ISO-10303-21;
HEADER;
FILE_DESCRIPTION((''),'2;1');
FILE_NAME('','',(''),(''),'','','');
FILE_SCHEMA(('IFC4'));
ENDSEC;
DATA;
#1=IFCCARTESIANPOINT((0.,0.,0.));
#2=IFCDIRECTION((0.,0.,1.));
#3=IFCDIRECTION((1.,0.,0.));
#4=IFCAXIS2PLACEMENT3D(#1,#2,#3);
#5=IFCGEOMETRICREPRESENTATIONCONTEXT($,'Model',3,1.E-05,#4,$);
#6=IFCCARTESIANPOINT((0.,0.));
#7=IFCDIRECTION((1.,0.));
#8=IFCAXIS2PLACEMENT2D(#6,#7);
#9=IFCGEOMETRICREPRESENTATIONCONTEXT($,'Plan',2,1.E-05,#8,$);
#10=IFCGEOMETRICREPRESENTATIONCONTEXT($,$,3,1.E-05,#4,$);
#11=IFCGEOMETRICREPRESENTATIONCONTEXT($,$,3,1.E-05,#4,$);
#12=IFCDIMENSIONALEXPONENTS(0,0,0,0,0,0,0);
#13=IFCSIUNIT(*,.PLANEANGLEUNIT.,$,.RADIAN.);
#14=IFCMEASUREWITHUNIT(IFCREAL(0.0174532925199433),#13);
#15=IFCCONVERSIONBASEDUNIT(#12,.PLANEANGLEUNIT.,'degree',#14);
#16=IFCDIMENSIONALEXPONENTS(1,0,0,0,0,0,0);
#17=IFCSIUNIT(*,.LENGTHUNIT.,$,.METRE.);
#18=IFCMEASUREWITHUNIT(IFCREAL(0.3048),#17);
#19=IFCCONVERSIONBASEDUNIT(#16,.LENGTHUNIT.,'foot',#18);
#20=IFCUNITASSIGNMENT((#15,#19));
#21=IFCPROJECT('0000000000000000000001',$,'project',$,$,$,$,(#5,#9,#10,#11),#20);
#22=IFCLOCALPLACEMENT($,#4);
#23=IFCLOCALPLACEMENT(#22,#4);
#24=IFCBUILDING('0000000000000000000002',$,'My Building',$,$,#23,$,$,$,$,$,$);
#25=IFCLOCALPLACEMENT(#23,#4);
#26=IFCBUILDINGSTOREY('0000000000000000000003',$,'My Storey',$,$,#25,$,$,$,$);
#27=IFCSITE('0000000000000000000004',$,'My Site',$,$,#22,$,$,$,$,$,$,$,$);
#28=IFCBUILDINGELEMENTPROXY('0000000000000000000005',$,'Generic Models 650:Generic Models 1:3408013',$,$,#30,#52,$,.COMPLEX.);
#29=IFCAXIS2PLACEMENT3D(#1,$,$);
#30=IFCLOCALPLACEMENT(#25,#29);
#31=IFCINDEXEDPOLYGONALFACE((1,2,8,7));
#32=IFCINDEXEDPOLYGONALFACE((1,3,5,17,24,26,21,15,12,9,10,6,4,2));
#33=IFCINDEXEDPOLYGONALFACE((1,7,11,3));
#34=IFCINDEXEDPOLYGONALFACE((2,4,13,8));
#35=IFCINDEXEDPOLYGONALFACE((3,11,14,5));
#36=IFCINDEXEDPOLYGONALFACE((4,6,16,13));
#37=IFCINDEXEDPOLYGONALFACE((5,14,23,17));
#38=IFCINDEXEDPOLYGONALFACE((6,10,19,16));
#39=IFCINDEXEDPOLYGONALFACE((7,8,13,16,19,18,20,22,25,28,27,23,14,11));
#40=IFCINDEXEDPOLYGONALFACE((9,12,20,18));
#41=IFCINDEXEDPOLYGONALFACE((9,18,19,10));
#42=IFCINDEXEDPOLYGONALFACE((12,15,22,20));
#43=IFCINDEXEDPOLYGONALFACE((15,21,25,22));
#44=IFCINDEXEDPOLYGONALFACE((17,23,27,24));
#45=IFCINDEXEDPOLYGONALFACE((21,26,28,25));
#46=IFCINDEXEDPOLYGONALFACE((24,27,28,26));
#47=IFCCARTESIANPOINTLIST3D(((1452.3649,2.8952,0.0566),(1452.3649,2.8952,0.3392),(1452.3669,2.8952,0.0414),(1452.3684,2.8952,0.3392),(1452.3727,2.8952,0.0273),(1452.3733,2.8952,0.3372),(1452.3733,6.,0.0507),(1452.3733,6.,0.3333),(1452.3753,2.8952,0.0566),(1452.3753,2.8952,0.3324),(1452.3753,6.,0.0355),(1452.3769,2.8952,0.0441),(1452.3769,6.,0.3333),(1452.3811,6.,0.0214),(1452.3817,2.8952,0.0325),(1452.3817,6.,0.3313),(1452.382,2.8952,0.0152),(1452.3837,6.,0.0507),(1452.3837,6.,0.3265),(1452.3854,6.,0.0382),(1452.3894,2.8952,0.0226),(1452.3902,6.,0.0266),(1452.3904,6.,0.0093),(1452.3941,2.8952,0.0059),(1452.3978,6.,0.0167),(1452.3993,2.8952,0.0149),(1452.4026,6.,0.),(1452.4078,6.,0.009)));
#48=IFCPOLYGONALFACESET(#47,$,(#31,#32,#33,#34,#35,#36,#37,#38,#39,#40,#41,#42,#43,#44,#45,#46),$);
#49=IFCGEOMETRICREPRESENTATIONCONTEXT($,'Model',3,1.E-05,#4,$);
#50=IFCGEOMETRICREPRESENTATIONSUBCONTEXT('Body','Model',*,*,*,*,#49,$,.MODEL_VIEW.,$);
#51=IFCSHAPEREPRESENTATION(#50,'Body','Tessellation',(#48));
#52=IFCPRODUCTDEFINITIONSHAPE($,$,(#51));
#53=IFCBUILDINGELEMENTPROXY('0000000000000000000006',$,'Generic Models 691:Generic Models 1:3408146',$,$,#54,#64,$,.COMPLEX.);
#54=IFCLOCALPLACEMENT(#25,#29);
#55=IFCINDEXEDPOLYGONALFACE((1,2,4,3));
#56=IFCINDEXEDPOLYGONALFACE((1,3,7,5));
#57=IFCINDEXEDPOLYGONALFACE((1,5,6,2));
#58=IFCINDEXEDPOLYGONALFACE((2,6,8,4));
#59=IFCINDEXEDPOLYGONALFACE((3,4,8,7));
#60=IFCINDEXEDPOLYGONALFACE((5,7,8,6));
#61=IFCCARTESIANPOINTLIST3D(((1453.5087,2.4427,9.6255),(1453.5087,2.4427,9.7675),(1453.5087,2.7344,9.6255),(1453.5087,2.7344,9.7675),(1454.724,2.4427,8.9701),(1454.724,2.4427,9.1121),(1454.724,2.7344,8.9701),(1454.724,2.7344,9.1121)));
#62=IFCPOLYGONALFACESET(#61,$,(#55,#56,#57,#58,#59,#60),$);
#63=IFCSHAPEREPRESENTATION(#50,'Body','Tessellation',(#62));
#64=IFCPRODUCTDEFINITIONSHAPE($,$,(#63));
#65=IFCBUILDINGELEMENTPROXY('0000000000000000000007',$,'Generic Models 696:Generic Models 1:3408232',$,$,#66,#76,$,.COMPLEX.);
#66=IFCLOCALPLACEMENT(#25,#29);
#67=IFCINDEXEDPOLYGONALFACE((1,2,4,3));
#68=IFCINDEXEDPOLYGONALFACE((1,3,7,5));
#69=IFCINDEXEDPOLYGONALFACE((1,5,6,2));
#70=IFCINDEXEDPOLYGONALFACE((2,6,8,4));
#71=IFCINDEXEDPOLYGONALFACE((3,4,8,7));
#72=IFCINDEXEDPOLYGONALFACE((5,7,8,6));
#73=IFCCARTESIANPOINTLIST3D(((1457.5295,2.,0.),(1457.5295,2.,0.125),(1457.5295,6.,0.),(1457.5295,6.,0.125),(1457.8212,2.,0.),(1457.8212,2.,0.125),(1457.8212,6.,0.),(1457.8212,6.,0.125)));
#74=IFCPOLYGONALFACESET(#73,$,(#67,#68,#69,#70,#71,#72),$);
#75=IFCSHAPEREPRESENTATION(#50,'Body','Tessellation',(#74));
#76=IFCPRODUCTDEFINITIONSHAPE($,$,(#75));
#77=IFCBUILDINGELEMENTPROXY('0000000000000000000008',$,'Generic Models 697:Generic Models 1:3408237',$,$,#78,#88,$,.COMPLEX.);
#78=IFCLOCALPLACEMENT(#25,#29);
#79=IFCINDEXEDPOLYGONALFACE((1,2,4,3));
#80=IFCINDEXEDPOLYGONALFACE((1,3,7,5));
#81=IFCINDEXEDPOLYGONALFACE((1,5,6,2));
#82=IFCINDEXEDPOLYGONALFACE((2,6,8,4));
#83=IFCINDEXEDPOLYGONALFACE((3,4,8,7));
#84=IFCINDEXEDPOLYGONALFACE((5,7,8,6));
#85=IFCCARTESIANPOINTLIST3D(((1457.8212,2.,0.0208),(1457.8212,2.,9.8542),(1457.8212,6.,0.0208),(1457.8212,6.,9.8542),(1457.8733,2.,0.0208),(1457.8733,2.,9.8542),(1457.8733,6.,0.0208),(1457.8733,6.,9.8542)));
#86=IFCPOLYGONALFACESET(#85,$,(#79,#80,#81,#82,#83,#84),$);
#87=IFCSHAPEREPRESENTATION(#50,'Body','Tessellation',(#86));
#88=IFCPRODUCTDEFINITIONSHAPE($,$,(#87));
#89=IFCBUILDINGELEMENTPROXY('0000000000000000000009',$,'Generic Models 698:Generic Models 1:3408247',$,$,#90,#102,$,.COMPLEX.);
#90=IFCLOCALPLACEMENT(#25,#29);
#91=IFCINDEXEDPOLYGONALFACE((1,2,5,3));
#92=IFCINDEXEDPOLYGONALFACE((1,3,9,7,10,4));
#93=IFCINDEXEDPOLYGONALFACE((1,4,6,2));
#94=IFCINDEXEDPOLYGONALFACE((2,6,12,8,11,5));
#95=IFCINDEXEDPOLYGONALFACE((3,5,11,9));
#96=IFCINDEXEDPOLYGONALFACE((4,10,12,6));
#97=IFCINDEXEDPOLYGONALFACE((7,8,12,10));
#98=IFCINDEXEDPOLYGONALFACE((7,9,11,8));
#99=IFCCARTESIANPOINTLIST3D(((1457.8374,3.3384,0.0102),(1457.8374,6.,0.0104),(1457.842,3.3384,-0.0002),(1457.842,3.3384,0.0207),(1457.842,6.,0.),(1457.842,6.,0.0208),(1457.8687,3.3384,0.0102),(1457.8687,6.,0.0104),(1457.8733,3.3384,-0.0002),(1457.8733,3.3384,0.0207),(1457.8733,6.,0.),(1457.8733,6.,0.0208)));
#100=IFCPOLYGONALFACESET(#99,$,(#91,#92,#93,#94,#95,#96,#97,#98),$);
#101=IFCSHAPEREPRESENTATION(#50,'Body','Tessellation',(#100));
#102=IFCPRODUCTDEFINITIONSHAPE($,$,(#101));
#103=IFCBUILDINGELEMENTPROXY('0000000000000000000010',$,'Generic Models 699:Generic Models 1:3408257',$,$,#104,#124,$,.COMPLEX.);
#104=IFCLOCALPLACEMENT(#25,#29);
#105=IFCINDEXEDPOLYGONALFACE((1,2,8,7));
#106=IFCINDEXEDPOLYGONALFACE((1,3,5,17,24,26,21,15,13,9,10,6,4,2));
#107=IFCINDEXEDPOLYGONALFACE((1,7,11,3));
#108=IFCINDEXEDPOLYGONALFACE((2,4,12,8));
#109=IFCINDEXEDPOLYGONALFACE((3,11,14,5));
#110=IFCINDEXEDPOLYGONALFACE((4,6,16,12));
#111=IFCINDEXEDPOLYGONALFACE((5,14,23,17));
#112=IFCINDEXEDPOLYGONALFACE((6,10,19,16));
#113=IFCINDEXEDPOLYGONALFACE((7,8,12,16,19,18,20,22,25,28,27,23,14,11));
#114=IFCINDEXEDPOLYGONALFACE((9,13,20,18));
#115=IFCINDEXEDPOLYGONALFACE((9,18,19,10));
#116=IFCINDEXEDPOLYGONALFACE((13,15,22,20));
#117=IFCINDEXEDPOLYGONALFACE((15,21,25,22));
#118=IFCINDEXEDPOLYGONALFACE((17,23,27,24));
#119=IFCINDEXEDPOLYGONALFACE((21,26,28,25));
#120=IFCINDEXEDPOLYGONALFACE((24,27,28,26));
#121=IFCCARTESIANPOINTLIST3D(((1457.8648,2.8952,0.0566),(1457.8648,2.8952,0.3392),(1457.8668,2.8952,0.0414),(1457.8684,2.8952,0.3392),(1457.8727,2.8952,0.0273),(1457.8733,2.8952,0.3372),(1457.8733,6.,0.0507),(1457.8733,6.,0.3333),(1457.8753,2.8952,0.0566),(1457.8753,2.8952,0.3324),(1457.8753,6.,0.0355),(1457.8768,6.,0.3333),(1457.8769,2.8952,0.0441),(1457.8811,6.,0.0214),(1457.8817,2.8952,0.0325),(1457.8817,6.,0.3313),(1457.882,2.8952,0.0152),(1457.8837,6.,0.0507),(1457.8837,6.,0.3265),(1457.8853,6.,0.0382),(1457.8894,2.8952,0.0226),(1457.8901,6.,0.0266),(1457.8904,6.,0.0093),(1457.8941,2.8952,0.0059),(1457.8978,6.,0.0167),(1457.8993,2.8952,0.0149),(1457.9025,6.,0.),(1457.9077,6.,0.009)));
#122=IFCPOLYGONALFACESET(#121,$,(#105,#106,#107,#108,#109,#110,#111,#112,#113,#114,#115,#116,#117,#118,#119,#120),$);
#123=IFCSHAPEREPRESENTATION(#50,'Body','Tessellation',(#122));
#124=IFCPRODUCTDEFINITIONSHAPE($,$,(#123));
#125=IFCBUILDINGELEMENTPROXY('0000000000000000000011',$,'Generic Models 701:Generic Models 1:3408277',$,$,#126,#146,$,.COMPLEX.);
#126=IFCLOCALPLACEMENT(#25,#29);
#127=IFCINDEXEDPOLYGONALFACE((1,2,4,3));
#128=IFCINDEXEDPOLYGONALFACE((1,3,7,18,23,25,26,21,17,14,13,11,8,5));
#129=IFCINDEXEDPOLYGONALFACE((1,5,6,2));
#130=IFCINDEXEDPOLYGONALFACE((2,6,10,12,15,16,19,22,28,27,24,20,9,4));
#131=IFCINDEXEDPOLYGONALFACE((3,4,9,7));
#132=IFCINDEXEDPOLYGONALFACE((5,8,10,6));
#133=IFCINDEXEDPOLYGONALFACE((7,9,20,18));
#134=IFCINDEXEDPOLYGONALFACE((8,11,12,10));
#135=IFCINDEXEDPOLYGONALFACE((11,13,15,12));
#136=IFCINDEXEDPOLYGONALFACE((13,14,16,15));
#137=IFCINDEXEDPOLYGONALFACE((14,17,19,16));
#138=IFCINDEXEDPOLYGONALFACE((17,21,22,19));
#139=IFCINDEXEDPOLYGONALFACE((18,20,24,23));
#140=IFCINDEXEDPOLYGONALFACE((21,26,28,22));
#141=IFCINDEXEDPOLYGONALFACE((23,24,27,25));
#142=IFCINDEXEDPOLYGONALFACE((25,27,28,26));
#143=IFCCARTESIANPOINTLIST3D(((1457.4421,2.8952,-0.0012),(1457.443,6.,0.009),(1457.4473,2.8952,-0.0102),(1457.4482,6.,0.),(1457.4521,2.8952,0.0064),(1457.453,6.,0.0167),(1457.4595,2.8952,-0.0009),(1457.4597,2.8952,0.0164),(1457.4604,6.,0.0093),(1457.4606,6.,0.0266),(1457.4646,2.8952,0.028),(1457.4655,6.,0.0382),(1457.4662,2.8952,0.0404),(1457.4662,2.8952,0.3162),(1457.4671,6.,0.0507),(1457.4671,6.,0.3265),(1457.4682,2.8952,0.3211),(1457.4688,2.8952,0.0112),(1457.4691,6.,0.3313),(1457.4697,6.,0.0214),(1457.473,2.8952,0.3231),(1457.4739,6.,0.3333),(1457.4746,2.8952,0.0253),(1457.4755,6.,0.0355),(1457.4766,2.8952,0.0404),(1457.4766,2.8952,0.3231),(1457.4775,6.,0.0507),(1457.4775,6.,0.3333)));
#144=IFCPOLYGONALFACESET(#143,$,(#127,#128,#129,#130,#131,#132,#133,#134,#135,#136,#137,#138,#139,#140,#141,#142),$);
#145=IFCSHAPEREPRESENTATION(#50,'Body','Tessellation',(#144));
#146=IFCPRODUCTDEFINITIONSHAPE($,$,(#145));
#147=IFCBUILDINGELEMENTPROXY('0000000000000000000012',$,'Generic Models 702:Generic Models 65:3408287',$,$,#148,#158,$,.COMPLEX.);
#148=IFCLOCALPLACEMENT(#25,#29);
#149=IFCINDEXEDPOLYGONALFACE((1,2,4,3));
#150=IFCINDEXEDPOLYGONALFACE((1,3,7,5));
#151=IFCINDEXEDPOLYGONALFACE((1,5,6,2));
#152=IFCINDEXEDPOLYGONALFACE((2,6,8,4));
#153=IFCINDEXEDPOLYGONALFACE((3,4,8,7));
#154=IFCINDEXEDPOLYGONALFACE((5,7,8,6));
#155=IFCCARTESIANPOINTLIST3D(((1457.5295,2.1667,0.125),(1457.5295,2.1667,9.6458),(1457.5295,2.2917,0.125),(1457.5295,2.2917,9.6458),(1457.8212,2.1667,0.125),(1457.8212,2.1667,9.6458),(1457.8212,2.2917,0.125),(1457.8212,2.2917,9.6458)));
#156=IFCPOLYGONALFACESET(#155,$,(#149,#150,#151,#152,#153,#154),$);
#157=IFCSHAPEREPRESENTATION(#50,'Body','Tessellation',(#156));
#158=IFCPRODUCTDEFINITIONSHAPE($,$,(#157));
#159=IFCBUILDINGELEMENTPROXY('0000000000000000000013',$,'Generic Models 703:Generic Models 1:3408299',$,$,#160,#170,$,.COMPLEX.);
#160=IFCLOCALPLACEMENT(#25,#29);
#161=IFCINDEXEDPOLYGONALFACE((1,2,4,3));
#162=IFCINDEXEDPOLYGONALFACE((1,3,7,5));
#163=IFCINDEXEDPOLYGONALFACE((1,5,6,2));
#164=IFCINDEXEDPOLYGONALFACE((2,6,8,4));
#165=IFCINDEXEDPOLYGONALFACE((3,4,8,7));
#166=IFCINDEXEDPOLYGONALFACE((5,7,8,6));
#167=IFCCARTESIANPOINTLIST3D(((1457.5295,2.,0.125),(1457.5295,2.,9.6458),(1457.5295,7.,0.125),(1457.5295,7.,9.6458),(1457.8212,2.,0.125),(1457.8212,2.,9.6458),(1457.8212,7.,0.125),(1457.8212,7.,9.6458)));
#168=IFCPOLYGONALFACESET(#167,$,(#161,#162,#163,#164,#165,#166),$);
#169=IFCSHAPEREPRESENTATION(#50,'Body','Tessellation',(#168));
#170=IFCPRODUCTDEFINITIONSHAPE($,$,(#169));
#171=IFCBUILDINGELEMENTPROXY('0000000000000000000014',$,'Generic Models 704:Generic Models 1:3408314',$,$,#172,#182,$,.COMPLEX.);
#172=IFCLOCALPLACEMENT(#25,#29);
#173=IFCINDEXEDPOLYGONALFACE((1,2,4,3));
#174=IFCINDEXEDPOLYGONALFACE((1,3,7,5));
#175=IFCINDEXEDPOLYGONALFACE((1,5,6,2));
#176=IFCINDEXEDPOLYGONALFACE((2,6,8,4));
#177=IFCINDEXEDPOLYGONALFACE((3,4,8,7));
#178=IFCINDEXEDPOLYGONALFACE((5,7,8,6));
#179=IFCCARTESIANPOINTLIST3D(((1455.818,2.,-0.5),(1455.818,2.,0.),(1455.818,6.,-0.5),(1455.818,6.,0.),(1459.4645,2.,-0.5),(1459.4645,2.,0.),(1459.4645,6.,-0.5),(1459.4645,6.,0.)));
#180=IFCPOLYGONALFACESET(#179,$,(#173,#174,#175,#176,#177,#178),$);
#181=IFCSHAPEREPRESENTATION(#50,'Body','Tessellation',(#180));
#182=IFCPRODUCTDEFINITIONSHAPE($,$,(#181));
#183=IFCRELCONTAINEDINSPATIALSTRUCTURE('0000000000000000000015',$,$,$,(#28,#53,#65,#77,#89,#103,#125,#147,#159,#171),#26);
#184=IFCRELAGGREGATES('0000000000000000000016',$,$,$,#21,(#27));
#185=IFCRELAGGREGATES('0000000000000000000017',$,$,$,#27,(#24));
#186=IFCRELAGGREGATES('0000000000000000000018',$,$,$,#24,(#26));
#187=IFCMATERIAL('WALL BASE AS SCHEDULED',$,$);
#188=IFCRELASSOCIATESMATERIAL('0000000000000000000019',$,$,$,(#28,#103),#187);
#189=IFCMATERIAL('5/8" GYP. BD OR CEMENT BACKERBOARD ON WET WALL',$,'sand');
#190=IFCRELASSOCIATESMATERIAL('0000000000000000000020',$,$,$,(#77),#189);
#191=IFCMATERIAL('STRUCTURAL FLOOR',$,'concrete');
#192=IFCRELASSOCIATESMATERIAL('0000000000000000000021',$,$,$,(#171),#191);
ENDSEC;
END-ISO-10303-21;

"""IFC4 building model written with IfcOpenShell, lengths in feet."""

from ifc_helpers import new_model, entity, si_unit, converted_unit, frame, origin_with_axes, origin_2d_with_axis, place, context, subcontext, project, spatial, polyline, outline, extrude, material, element, save


model = new_model("IFC4")

# Units and contexts
model_context_1 = context("Model", 3, precision=1e-05, world=origin_with_axes())
plan_context = context("Plan", 2, precision=1e-05, world=origin_2d_with_axis())
model_context_2 = context("Model", 3, precision=1e-05, world=origin_with_axes())
context_of_model_1 = context(None, 3, precision=1e-05, world=origin_with_axes())
context_of_model_2 = context(None, 3, precision=1e-05, world=origin_with_axes())
body_context = subcontext(model_context_2, "Body", "Model", "MODEL_VIEW")
ifc_project = project(units=[converted_unit("PLANEANGLEUNIT", "degree", entity("IfcReal", 0.0174532925199433), si_unit("PLANEANGLEUNIT", "RADIAN"), dimensions=[0, 0, 0, 0, 0, 0, 0]), converted_unit("LENGTHUNIT", "foot", entity("IfcReal", 0.3048), si_unit("LENGTHUNIT", "METRE"), dimensions=[1, 0, 0, 0, 0, 0, 0])], contexts=[model_context_1, plan_context, context_of_model_1, context_of_model_2])

# Site, building, storey
site_placement = place(None, origin_with_axes())
site = spatial("IfcSite", under=ifc_project, at=site_placement, Name="My Site")
building_placement = place(site_placement, origin_with_axes())
building = spatial("IfcBuilding", under=site, at=building_placement, Name="My Building")
storey_placement = place(building_placement, origin_with_axes())
storey = spatial("IfcBuildingStorey", under=building, at=storey_placement, Name="My Storey")

# Building element proxies
ifc_material_1 = material(Name="WALL BASE AS SCHEDULED")
proxy_1_placement = place(storey_placement, frame((1452.3733, 6.0, 0.0), z_axis=(0.0, -1.0, 0.0), x_axis=(0.0, 0.0, 1.0)))
element("IfcBuildingElementProxy", 1, at=proxy_1_placement, inside=storey, material=ifc_material_1, Name="Generic Models 650:Generic Models 1:3408013", PredefinedType="COMPLEX", context=body_context, shape_type="SweptSolid", body=[
    extrude(outline(polyline([(0.2206, 0.0), (0.2204, 0.0036), (0.2182, 0.0083), (0.2132, 0.01), (-0.0621, -0.0058), (-0.0747, -0.0049), (-0.0865, -0.0007), (-0.0969, 0.0063), (-0.1051, 0.0158), (-0.1138, 0.0101), (-0.1038, -0.0014), (-0.0912, -0.01), (-0.0768, -0.0151), (-0.0615, -0.0162), (0.2206, 0.0)])), frame((0.113, -0.0126, 0.0), z_axis=(0.0, 0.0, -1.0), x_axis=(0.998358, 0.057286, 0.0)), (0.002054, -0.002598, -0.999995), 3.1048),
])
proxy_2_placement = place(storey_placement, frame((1453.5087, 2.7344, 8.9701), z_axis=(0.0, -1.0, 0.0), x_axis=(1.0, 0.0, 0.0)))
element("IfcBuildingElementProxy", 2, at=proxy_2_placement, inside=storey, Name="Generic Models 691:Generic Models 1:3408146", PredefinedType="COMPLEX", context=body_context, shape_type="SweptSolid", body=[
    extrude(outline(polyline([(0.2567, -0.6077), (0.3987, -0.6077), (-0.2567, 0.6077), (-0.3987, 0.6077), (0.2567, -0.6077)])), frame((0.6077, 0.3987, 0.0), z_axis=(0.0, 0.0, -1.0), x_axis=(0.0, 1.0, 0.0)), (0.0, 0.0, -1.0), 0.2917),
])
proxy_3_placement = place(storey_placement, frame((1457.5295, 6.0, 0.0), z_axis=(0.0, -1.0, 0.0), x_axis=(0.0, 0.0, 1.0)))
element("IfcBuildingElementProxy", 3, at=proxy_3_placement, inside=storey, Name="Generic Models 696:Generic Models 1:3408232", PredefinedType="COMPLEX", context=body_context, shape_type="SweptSolid", body=[
    extrude(outline(polyline([(-0.0625, -0.1458), (0.0625, -0.1458), (0.0625, 0.1458), (-0.0625, 0.1458), (-0.0625, -0.1458)])), frame((0.0625, -0.1458, 0.0), z_axis=(0.0, 0.0, -1.0), x_axis=(1.0, 0.0, 0.0)), (0.0, 0.0, -1.0), 4.0),
])
ifc_material_2 = material(Name="5/8\" GYP. BD OR CEMENT BACKERBOARD ON WET WALL", Category="sand")
proxy_4_placement = place(storey_placement, frame((1457.8212, 6.0, 0.0208), z_axis=(0.0, -1.0, 0.0), x_axis=(0.0, 0.0, 1.0)))
element("IfcBuildingElementProxy", 4, at=proxy_4_placement, inside=storey, material=ifc_material_2, Name="Generic Models 697:Generic Models 1:3408237", PredefinedType="COMPLEX", context=body_context, shape_type="SweptSolid", body=[
    extrude(outline(polyline([(-4.9167, -0.026), (4.9167, -0.026), (4.9167, 0.026), (-4.9167, 0.026), (-4.9167, -0.026)])), frame((4.9167, -0.026, 0.0), z_axis=(0.0, 0.0, -1.0), x_axis=(1.0, 0.0, 0.0)), (0.0, 0.0, -1.0), 4.0),
])
proxy_5_placement = place(storey_placement, frame((1457.8375, 6.0, 0.0), z_axis=(0.0, -1.0, 0.0), x_axis=(0.0, 0.0, 1.0)))
element("IfcBuildingElementProxy", 5, at=proxy_5_placement, inside=storey, Name="Generic Models 698:Generic Models 1:3408247", PredefinedType="COMPLEX", context=body_context, shape_type="SweptSolid", body=[
    extrude(outline(polyline([(0.0201, 0.0), (0.0107, 0.0065), (0.0093, 0.0178), (-0.0175, 0.0016), (-0.016, -0.0097), (-0.0066, -0.0162), (0.0201, 0.0)])), frame((0.0104, -0.0186, 0.0), z_axis=(0.0, 0.0, -1.0), x_axis=(0.51911, -0.854707, 0.0)), (-0.000034, 0.000057, -1.0), 2.6616),
])
proxy_6_placement = place(storey_placement, frame((1457.8733, 6.0, 0.0), z_axis=(0.0, -1.0, 0.0), x_axis=(0.0, 0.0, 1.0)))
element("IfcBuildingElementProxy", 6, at=proxy_6_placement, inside=storey, material=ifc_material_1, Name="Generic Models 699:Generic Models 1:3408257", PredefinedType="COMPLEX", context=body_context, shape_type="SweptSolid", body=[
    extrude(outline(polyline([(0.2206, 0.0), (0.2204, 0.0036), (0.2182, 0.0083), (0.2132, 0.01), (-0.0621, -0.0058), (-0.0747, -0.0049), (-0.0865, -0.0007), (-0.0969, 0.0063), (-0.1051, 0.0158), (-0.1138, 0.0101), (-0.1038, -0.0014), (-0.0912, -0.01), (-0.0768, -0.0151), (-0.0615, -0.0162), (0.2206, 0.0)])), frame((0.113, -0.0126, 0.0), z_axis=(0.0, 0.0, -1.0), x_axis=(0.998358, 0.057286, 0.0)), (0.002054, -0.002598, -0.999995), 3.1048),
])
proxy_7_placement = place(storey_placement, frame((1457.443, 6.0, 0.0), z_axis=(0.0, -1.0, 0.0), x_axis=(0.0, 0.0, 1.0)))
element("IfcBuildingElementProxy", 7, at=proxy_7_placement, inside=storey, Name="Generic Models 701:Generic Models 1:3408277", PredefinedType="COMPLEX", context=body_context, shape_type="SweptSolid", body=[
    extrude(outline(polyline([(-0.0624, 0.0022), (0.2134, 0.0022), (0.2183, 0.0042), (0.2203, 0.0091), (0.2203, 0.0126), (-0.0624, 0.0126), (-0.0775, 0.0106), (-0.0916, 0.0048), (-0.1037, -0.0045), (-0.113, -0.0166), (-0.104, -0.0218), (-0.0964, -0.0119), (-0.0864, -0.0042), (-0.0748, 0.0006), (-0.0624, 0.0022)])), frame((0.113, -0.0218, 0.0), z_axis=(0.0, 0.0, -1.0), x_axis=(1.0, 0.0, 0.0)), (-0.003299, -0.000291, -0.999995), 3.1048),
])
proxy_8_placement = place(storey_placement, frame((1457.5295, 2.1667, 0.125), z_axis=(0.0, 0.0, 1.0), x_axis=(1.0, 0.0, 0.0)))
element("IfcBuildingElementProxy", 8, at=proxy_8_placement, inside=storey, Name="Generic Models 702:Generic Models 65:3408287", PredefinedType="COMPLEX", context=body_context, shape_type="SweptSolid", body=[
    extrude(outline(polyline([(-0.1458, -0.0625), (0.1458, -0.0625), (0.1458, 0.0625), (-0.1458, 0.0625), (-0.1458, -0.0625)])), frame((0.1458, 0.0625, 0.0), z_axis=(0.0, 0.0, -1.0), x_axis=(-1.0, 0.0, 0.0)), (0.0, 0.0, -1.0), 9.5208),
])
proxy_9_placement = place(storey_placement, frame((1457.5295, 6.0, 0.125), z_axis=(0.0, -1.0, 0.0), x_axis=(0.0, 0.0, 1.0)))
element("IfcBuildingElementProxy", 9, at=proxy_9_placement, inside=storey, Name="Generic Models 703:Generic Models 1:3408299", PredefinedType="COMPLEX", context=body_context, shape_type="SweptSolid", body=[
    extrude(outline(polyline([(-4.7604, -0.1458), (4.7604, -0.1458), (4.7604, 0.1458), (-4.7604, 0.1458), (-4.7604, -0.1458)])), frame((4.7604, -0.1458, -1.0), z_axis=(0.0, 0.0, -1.0), x_axis=(1.0, 0.0, 0.0)), (0.0, 0.0, -1.0), 5.0),
])
ifc_material_3 = material(Name="STRUCTURAL FLOOR", Category="concrete")
proxy_10_placement = place(storey_placement, frame((1455.818, 6.0, -0.5), z_axis=(0.0, -1.0, 0.0), x_axis=(0.0, 0.0, 1.0)))
element("IfcBuildingElementProxy", 10, at=proxy_10_placement, inside=storey, material=ifc_material_3, Name="Generic Models 704:Generic Models 1:3408314", PredefinedType="COMPLEX", context=body_context, shape_type="SweptSolid", body=[
    extrude(outline(polyline([(-0.25, -1.8232), (0.25, -1.8232), (0.25, 1.8232), (-0.25, 1.8232), (-0.25, -1.8232)])), frame((0.25, -1.8232, 0.0), z_axis=(0.0, 0.0, -1.0), x_axis=(1.0, 0.0, 0.0)), (0.0, 0.0, -1.0), 4.0),
])

save(model, "model.ifc")
